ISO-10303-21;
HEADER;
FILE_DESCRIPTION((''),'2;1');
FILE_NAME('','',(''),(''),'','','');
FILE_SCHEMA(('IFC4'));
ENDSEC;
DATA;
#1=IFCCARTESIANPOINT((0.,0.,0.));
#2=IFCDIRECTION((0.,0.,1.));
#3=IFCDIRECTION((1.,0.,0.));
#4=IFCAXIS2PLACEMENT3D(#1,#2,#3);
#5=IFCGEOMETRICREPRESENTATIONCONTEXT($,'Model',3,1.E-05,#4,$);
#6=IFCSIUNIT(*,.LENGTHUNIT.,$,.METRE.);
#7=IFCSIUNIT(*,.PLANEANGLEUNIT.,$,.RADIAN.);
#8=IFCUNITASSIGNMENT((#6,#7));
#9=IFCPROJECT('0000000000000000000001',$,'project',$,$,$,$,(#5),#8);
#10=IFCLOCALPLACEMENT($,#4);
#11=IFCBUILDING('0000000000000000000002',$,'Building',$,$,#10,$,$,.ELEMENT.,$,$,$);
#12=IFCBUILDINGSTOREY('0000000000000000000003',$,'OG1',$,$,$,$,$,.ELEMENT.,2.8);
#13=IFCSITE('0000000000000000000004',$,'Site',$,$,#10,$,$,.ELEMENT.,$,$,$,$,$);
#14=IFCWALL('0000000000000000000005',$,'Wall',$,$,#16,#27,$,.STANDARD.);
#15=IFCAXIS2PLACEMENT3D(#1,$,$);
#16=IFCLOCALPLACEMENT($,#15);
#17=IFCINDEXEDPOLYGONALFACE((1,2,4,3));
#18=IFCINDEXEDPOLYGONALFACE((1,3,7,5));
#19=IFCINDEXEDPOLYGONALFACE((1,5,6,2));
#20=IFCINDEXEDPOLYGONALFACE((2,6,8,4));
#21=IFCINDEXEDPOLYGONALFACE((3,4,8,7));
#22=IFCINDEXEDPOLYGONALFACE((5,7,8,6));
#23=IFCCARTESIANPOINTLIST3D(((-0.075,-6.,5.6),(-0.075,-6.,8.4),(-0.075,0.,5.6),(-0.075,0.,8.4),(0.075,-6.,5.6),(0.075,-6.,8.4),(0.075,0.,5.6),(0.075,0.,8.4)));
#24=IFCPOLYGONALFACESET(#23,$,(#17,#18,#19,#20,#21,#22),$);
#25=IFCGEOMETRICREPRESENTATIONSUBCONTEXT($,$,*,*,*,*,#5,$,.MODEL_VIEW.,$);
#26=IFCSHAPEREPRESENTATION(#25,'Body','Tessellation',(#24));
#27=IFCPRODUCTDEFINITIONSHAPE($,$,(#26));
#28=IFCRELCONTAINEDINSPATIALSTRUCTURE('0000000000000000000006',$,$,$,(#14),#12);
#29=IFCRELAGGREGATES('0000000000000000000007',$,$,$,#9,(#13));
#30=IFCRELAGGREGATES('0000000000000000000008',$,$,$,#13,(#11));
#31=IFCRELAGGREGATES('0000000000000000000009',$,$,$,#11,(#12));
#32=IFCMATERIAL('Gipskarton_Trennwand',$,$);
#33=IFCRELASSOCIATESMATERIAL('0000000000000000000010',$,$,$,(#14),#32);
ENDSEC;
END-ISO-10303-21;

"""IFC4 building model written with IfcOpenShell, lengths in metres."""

from ifc_helpers import new_model, si_unit, frame, frame_2d, origin, origin_with_axes, place, context, subcontext, project, spatial, rectangle, extrude, material, element, save


model = new_model("IFC4")

# Units and contexts
model_context = context("Model", 3, precision=1e-05, world=origin_with_axes())
sub_context = subcontext(model_context, None, None, "MODEL_VIEW")
ifc_project = project(units=[si_unit("LENGTHUNIT", "METRE"), si_unit("PLANEANGLEUNIT", "RADIAN")], contexts=[model_context])

# Site, building, storey
placement_1 = place(None, origin_with_axes())
site = spatial("IfcSite", under=ifc_project, at=placement_1, Name="Site", CompositionType="ELEMENT")
building = spatial("IfcBuilding", under=site, at=placement_1, Name="Building", CompositionType="ELEMENT")
storey = spatial("IfcBuildingStorey", under=building, Name="OG1", CompositionType="ELEMENT", Elevation=2.8)

# Wall
ifc_material = material(Name="Gipskarton_Trennwand")
placement_2 = place(None, origin_with_axes())
placement_3 = place(placement_2, frame((0.0, 0.0, 2.8)))
wall_placement = place(placement_3, frame((0.0, -6.0, 2.8), x_axis=(0.0, 1.0, 0.0)))
element("IfcWall", 1, at=wall_placement, inside=storey, material=ifc_material, Name="Wall", PredefinedType="STANDARD", context=sub_context, shape_type="SweptSolid", body=[
    extrude(rectangle(XDim=6.0, YDim=0.15, at=frame_2d((3.0, 0.0))), origin(), (0.0, 0.0, 1.0), 2.8),
])

save(model, "model.ifc")
